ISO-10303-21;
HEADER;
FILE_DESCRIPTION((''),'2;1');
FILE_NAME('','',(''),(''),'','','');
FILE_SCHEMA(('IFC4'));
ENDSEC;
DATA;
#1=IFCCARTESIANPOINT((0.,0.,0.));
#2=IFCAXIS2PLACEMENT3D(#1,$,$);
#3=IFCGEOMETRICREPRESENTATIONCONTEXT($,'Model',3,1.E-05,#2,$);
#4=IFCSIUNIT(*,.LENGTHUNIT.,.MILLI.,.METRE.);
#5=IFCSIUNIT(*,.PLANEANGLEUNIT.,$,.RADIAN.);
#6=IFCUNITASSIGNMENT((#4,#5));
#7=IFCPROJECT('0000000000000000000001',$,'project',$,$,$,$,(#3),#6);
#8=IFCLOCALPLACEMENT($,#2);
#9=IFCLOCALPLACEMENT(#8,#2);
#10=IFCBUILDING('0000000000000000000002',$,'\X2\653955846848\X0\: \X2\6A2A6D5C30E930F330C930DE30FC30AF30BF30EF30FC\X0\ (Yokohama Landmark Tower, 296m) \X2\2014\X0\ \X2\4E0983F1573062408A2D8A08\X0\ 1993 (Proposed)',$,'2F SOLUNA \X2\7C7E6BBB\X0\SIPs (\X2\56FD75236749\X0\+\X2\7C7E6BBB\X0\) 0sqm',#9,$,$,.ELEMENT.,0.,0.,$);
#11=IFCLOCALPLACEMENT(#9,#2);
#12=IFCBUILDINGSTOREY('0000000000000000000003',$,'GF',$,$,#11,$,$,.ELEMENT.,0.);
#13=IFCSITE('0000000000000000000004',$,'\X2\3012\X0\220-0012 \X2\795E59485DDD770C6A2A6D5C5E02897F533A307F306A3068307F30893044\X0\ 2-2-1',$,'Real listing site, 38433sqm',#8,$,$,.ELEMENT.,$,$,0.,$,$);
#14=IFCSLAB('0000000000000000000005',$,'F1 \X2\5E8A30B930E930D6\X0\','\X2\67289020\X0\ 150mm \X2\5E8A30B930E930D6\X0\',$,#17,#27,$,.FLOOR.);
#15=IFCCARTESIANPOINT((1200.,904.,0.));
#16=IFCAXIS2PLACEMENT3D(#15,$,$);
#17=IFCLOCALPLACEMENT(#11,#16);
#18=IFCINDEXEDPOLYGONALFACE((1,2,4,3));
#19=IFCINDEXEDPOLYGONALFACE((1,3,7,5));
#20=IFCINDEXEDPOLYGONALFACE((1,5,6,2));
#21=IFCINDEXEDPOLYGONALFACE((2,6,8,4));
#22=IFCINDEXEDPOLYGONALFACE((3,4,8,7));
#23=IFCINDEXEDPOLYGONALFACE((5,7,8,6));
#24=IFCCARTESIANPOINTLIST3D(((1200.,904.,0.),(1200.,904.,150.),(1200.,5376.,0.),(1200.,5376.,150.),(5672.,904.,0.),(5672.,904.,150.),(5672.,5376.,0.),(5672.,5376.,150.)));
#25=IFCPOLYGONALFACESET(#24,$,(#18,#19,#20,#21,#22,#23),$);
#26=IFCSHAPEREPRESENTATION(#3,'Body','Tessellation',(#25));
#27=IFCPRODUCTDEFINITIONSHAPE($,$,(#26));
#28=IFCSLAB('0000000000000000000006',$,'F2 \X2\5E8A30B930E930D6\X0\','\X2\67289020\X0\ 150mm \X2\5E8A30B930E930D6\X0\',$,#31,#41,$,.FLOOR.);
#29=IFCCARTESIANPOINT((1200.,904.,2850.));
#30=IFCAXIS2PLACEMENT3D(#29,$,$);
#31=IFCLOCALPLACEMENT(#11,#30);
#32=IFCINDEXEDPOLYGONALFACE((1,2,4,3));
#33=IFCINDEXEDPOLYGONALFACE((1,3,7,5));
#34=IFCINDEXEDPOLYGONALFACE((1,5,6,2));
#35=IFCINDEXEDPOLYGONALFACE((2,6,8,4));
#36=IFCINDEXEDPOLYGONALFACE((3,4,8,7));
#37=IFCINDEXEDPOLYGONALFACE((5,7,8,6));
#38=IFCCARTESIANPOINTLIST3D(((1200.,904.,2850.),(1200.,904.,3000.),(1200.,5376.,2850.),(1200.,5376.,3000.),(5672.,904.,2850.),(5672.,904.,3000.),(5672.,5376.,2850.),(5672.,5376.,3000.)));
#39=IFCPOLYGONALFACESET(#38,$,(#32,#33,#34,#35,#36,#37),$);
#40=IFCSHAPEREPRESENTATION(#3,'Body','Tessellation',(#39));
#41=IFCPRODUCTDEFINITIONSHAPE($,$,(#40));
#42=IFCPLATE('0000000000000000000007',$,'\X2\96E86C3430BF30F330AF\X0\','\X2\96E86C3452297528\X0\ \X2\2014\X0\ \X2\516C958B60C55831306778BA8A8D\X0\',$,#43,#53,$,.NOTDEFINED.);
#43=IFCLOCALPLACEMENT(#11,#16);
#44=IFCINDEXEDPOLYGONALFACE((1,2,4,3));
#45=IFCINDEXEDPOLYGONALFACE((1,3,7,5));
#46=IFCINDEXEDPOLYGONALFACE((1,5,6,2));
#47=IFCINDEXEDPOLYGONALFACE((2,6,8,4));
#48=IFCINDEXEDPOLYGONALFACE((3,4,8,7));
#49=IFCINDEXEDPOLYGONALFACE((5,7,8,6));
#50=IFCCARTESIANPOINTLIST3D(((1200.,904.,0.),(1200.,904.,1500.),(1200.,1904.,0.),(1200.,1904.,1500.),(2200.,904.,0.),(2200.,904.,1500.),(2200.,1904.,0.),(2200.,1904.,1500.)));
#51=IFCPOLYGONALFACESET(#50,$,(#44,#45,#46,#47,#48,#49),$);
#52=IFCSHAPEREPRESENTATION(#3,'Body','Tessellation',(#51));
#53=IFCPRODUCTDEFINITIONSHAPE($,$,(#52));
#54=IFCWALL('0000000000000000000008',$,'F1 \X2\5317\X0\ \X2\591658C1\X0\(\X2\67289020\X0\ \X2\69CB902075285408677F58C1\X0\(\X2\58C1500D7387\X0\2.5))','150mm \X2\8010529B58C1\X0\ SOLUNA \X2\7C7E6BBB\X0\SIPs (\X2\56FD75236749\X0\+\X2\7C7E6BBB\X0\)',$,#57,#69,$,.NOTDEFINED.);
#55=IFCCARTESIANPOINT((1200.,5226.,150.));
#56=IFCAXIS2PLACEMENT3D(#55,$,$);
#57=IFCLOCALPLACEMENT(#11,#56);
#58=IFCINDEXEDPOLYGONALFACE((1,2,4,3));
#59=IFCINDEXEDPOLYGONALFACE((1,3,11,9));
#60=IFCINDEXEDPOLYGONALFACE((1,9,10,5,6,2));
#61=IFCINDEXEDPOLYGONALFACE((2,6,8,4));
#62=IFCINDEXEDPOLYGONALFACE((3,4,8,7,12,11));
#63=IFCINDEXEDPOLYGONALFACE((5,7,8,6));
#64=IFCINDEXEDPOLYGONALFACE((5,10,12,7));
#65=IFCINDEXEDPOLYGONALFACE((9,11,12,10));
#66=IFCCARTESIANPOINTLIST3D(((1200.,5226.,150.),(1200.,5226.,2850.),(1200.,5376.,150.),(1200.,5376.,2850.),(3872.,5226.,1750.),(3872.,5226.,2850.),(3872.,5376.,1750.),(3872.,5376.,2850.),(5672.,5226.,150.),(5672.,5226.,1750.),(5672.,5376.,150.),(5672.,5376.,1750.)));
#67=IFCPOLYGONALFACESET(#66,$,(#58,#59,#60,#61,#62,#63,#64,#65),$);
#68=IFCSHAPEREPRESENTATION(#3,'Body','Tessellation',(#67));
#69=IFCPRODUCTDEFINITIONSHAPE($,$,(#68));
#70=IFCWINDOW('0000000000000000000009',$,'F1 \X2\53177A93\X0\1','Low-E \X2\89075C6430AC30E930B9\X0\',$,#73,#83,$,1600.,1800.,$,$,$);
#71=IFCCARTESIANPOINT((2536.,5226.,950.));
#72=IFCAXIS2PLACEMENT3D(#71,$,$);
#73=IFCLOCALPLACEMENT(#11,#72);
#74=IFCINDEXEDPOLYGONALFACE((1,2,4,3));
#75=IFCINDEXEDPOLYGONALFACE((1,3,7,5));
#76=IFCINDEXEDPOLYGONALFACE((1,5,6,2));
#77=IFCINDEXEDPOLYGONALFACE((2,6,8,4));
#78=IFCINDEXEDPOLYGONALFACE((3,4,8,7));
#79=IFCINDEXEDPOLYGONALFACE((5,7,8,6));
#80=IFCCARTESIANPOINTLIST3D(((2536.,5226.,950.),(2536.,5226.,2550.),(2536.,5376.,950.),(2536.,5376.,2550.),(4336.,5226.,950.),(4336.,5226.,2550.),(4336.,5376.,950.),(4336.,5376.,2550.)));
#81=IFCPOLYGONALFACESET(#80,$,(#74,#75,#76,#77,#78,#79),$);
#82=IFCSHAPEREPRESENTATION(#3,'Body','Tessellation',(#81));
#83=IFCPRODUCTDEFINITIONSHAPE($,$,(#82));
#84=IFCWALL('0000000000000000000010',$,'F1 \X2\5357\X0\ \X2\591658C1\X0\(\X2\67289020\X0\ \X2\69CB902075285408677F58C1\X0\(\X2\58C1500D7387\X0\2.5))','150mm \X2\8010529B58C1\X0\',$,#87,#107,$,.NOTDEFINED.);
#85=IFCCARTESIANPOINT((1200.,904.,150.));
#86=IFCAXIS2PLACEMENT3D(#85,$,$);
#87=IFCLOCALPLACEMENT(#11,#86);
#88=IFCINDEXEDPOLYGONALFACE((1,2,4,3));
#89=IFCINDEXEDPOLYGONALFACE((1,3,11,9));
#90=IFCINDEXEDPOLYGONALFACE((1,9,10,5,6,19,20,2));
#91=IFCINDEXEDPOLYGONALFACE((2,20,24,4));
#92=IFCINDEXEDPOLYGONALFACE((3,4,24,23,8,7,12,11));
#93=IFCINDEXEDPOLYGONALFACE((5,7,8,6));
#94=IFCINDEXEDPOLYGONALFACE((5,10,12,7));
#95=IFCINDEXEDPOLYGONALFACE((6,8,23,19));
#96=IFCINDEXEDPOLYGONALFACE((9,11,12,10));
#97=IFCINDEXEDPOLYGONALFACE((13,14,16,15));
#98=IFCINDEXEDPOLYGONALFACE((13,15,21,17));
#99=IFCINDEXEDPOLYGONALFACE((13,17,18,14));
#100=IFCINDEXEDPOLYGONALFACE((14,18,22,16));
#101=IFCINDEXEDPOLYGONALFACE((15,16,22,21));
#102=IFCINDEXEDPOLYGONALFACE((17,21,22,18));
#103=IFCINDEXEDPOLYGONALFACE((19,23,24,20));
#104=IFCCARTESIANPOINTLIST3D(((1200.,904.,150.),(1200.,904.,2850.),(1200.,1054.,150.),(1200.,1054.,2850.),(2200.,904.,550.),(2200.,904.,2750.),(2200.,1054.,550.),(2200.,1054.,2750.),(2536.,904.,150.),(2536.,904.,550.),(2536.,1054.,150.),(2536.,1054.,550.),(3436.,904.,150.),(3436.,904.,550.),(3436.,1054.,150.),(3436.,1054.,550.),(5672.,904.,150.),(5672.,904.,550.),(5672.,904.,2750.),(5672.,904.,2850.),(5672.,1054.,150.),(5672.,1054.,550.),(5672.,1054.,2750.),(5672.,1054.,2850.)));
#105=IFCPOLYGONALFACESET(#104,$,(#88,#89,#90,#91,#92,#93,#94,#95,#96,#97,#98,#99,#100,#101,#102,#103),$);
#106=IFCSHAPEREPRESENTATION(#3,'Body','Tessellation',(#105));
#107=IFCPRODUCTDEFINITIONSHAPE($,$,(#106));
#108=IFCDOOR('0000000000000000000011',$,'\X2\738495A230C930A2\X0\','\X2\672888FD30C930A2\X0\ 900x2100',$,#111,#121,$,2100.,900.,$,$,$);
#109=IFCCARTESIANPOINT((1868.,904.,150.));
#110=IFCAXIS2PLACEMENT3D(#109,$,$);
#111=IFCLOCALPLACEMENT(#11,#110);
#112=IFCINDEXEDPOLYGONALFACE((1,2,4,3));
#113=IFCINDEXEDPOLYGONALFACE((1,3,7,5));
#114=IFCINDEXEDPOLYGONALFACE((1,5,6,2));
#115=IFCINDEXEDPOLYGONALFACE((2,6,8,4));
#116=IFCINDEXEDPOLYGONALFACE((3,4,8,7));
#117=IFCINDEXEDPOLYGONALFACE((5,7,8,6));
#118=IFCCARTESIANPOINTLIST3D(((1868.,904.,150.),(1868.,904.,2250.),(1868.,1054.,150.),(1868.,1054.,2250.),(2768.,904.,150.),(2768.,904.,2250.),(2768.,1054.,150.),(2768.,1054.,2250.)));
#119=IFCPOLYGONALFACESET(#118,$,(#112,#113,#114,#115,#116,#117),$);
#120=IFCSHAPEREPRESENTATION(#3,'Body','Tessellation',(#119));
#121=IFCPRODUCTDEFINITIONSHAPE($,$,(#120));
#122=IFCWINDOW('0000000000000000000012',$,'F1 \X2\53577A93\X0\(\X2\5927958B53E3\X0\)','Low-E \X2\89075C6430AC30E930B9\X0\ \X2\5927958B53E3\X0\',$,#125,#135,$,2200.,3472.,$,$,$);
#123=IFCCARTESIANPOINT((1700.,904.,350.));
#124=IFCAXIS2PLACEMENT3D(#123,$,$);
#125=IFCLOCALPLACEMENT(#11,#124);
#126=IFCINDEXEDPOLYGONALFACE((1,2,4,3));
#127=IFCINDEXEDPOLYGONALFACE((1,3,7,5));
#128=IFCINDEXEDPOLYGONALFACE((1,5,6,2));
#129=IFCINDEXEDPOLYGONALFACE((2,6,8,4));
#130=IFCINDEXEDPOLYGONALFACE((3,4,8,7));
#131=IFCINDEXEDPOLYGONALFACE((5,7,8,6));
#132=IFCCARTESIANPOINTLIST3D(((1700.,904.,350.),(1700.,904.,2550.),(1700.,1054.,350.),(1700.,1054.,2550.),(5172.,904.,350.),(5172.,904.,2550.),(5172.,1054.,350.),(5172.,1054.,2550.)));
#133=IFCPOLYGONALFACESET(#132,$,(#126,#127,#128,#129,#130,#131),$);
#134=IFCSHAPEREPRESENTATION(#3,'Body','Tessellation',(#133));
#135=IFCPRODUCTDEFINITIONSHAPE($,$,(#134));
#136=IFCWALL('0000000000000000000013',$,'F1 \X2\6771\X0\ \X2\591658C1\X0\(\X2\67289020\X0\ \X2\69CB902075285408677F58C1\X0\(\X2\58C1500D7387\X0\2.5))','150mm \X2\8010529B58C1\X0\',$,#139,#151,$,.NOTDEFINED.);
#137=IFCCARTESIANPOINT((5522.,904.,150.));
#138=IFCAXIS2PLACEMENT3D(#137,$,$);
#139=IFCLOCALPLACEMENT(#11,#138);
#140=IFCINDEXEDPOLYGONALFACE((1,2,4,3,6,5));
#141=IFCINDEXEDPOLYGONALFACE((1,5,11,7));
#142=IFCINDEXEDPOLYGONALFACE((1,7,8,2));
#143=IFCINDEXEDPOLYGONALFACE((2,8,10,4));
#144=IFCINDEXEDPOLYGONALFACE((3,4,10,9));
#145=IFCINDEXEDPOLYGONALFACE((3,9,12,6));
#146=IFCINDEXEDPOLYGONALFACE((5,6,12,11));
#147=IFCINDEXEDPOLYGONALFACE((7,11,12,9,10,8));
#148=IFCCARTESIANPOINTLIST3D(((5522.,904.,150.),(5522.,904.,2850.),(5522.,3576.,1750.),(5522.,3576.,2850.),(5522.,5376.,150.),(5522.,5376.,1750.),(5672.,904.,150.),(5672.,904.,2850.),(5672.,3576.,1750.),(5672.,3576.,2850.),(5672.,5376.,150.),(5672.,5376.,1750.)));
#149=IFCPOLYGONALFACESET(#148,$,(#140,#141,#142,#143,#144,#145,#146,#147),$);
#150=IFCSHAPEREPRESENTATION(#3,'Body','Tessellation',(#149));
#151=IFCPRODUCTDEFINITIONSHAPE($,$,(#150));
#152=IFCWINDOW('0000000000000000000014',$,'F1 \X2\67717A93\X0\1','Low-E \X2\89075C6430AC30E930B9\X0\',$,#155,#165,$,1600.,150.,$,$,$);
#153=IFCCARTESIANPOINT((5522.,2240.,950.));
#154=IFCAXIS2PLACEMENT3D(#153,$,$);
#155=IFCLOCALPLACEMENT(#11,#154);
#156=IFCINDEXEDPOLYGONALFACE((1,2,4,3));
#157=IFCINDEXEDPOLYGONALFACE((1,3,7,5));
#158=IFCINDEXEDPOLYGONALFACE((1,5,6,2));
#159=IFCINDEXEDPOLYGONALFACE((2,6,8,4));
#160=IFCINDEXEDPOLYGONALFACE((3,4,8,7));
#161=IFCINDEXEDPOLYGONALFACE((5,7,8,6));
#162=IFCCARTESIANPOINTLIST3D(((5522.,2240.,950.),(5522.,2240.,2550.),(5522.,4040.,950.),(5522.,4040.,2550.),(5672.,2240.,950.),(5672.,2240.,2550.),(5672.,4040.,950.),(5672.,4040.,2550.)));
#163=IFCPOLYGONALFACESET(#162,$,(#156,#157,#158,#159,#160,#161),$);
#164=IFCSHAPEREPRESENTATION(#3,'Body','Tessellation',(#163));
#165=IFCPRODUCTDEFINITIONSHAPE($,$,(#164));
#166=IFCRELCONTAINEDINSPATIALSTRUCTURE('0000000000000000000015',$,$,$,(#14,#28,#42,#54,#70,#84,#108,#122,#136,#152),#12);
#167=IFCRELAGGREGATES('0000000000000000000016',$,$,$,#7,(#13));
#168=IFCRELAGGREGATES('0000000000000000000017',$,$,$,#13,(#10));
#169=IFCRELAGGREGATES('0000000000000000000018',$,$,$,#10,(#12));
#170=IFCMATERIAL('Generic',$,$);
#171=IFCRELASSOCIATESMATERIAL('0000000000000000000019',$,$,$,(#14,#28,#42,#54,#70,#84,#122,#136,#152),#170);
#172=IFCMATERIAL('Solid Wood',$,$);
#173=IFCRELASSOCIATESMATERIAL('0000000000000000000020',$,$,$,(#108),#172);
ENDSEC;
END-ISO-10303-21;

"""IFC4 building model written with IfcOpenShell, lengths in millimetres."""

from ifc_helpers import new_model, si_unit, frame, frame_2d, origin, place, context, project, spatial, rectangle, extrude, material, element, fill, save


model = new_model("IFC4")

# Units and contexts
model_context = context("Model", 3, precision=1e-05, world=origin())
ifc_project = project(units=[si_unit("LENGTHUNIT", "METRE", prefix="MILLI"), si_unit("PLANEANGLEUNIT", "RADIAN")], contexts=[model_context])

# Site, building, storey
site_placement = place(None, origin())
site = spatial("IfcSite", under=ifc_project, at=site_placement, Name="〒220-0012 神奈川県横浜市西区みなとみらい 2-2-1", ObjectType="Real listing site, 38433sqm", CompositionType="ELEMENT", RefElevation=0.0)
building_placement = place(site_placement, origin())
building = spatial("IfcBuilding", under=site, at=building_placement, Name="改善案: 横浜ランドマークタワー (Yokohama Landmark Tower, 296m) — 三菱地所設計 1993 (Proposed)", ObjectType="2F SOLUNA 籾殻SIPs (国産杉+籾殻) 0sqm", CompositionType="ELEMENT", ElevationOfRefHeight=0.0, ElevationOfTerrain=0.0)
storey_placement = place(building_placement, origin())
storey = spatial("IfcBuildingStorey", under=building, at=storey_placement, Name="GF", CompositionType="ELEMENT", Elevation=0.0)

# Slabs
ifc_material_1 = material(Name="Generic")
slab_1_placement = place(storey_placement, frame((1200.0, 904.0, 0.0)))
element("IfcSlab", 1, at=slab_1_placement, inside=storey, material=ifc_material_1, Name="F1 床スラブ", Description="木造 150mm 床スラブ", PredefinedType="FLOOR", context=model_context, shape_type="SweptSolid", body=[
    extrude(rectangle(XDim=4472.0, YDim=4472.0, at=frame_2d((2236.0, 2236.0))), frame((1200.0, 904.0, 0.0)), (0.0, 0.0, 1.0), 150.0),
])
slab_2_placement = place(storey_placement, frame((1200.0, 904.0, 2850.0)))
element("IfcSlab", 2, at=slab_2_placement, inside=storey, material=ifc_material_1, Name="F2 床スラブ", Description="木造 150mm 床スラブ", PredefinedType="FLOOR", context=model_context, shape_type="SweptSolid", body=[
    extrude(rectangle(XDim=4472.0, YDim=4472.0, at=frame_2d((2236.0, 2236.0))), frame((1200.0, 904.0, 2850.0)), (0.0, 0.0, 1.0), 150.0),
])

# Plate
plate_placement = place(storey_placement, frame((1200.0, 904.0, 0.0)))
element("IfcPlate", 3, at=plate_placement, inside=storey, material=ifc_material_1, Name="雨水タンク", Description="雨水利用 — 公開情報で確認", PredefinedType="NOTDEFINED", context=model_context, shape_type="SweptSolid", body=[
    extrude(rectangle(XDim=1000.0, YDim=1000.0, at=frame_2d((500.0, 500.0))), frame((1200.0, 904.0, 0.0)), (0.0, 0.0, 1.0), 1500.0),
])

# Wall, opening, window
wall_1_placement = place(storey_placement, frame((1200.0, 5226.0, 150.0)))
wall_1 = element("IfcWall", 4, at=wall_1_placement, inside=storey, material=ifc_material_1, Name="F1 北 外壁(木造 構造用合板壁(壁倍率2.5))", Description="150mm 耐力壁 SOLUNA 籾殻SIPs (国産杉+籾殻)", PredefinedType="NOTDEFINED", context=model_context, shape_type="SweptSolid", body=[
    extrude(rectangle(XDim=4472.0, YDim=150.0, at=frame_2d((2236.0, 75.0))), frame((1200.0, 5226.0, 150.0)), (0.0, 0.0, 1.0), 2700.0),
])
opening_1_placement = place(storey_placement, frame((2536.0, 5226.0, 950.0)))
opening_1 = element("IfcOpeningElement", 5, at=opening_1_placement, cuts=wall_1, PredefinedType="NOTDEFINED", context=model_context, shape_type="SweptSolid", body=[
    extrude(rectangle(XDim=1800.0, YDim=150.0, at=frame_2d((900.0, 75.0))), frame((2536.0, 5226.0, 950.0)), (0.0, 0.0, 1.0), 1600.0),
])
window_1_placement = place(storey_placement, frame((2536.0, 5226.0, 950.0)))
window_1 = element("IfcWindow", 6, at=window_1_placement, inside=storey, material=ifc_material_1, Name="F1 北窓1", Description="Low-E 複層ガラス", OverallHeight=1600.0, OverallWidth=1800.0, context=model_context, shape_type="SweptSolid", body=[
    extrude(rectangle(XDim=1800.0, YDim=150.0, at=frame_2d((900.0, 75.0))), frame((2536.0, 5226.0, 950.0)), (0.0, 0.0, 1.0), 1600.0),
])
fill(opening_1, window_1)

# Wall, openings, door, window
wall_2_placement = place(storey_placement, frame((1200.0, 904.0, 150.0)))
wall_2 = element("IfcWall", 7, at=wall_2_placement, inside=storey, material=ifc_material_1, Name="F1 南 外壁(木造 構造用合板壁(壁倍率2.5))", Description="150mm 耐力壁", PredefinedType="NOTDEFINED", context=model_context, shape_type="SweptSolid", body=[
    extrude(rectangle(XDim=4472.0, YDim=150.0, at=frame_2d((2236.0, 75.0))), frame((1200.0, 904.0, 150.0)), (0.0, 0.0, 1.0), 2700.0),
])
opening_2_placement = place(storey_placement, frame((1868.0, 904.0, 150.0)))
opening_2 = element("IfcOpeningElement", 8, at=opening_2_placement, cuts=wall_2, PredefinedType="NOTDEFINED", context=model_context, shape_type="SweptSolid", body=[
    extrude(rectangle(XDim=900.0, YDim=150.0, at=frame_2d((450.0, 75.0))), frame((1868.0, 904.0, 150.0)), (0.0, 0.0, 1.0), 2100.0),
])
opening_3_placement = place(storey_placement, frame((1700.0, 904.0, 350.0)))
opening_3 = element("IfcOpeningElement", 9, at=opening_3_placement, cuts=wall_2, PredefinedType="NOTDEFINED", context=model_context, shape_type="SweptSolid", body=[
    extrude(rectangle(XDim=3472.0, YDim=150.0, at=frame_2d((1736.0, 75.0))), frame((1700.0, 904.0, 350.0)), (0.0, 0.0, 1.0), 2200.0),
])
ifc_material_2 = material(Name="Solid Wood")
door_placement = place(storey_placement, frame((1868.0, 904.0, 150.0)))
door = element("IfcDoor", 10, at=door_placement, inside=storey, material=ifc_material_2, Name="玄関ドア", Description="木製ドア 900x2100", OverallHeight=2100.0, OverallWidth=900.0, context=model_context, shape_type="SweptSolid", body=[
    extrude(rectangle(XDim=900.0, YDim=150.0, at=frame_2d((450.0, 75.0))), frame((1868.0, 904.0, 150.0)), (0.0, 0.0, 1.0), 2100.0),
])
fill(opening_2, door)
window_2_placement = place(storey_placement, frame((1700.0, 904.0, 350.0)))
window_2 = element("IfcWindow", 11, at=window_2_placement, inside=storey, material=ifc_material_1, Name="F1 南窓(大開口)", Description="Low-E 複層ガラス 大開口", OverallHeight=2200.0, OverallWidth=3472.0, context=model_context, shape_type="SweptSolid", body=[
    extrude(rectangle(XDim=3472.0, YDim=150.0, at=frame_2d((1736.0, 75.0))), frame((1700.0, 904.0, 350.0)), (0.0, 0.0, 1.0), 2200.0),
])
fill(opening_3, window_2)

# Wall, opening, window
wall_3_placement = place(storey_placement, frame((5522.0, 904.0, 150.0)))
wall_3 = element("IfcWall", 12, at=wall_3_placement, inside=storey, material=ifc_material_1, Name="F1 東 外壁(木造 構造用合板壁(壁倍率2.5))", Description="150mm 耐力壁", PredefinedType="NOTDEFINED", context=model_context, shape_type="SweptSolid", body=[
    extrude(rectangle(XDim=150.0, YDim=4472.0, at=frame_2d((75.0, 2236.0))), frame((5522.0, 904.0, 150.0)), (0.0, 0.0, 1.0), 2700.0),
])
opening_4_placement = place(storey_placement, frame((5522.0, 2240.0, 950.0)))
opening_4 = element("IfcOpeningElement", 13, at=opening_4_placement, cuts=wall_3, PredefinedType="NOTDEFINED", context=model_context, shape_type="SweptSolid", body=[
    extrude(rectangle(XDim=150.0, YDim=1800.0, at=frame_2d((75.0, 900.0))), frame((5522.0, 2240.0, 950.0)), (0.0, 0.0, 1.0), 1600.0),
])
window_3_placement = place(storey_placement, frame((5522.0, 2240.0, 950.0)))
window_3 = element("IfcWindow", 14, at=window_3_placement, inside=storey, material=ifc_material_1, Name="F1 東窓1", Description="Low-E 複層ガラス", OverallHeight=1600.0, OverallWidth=150.0, context=model_context, shape_type="SweptSolid", body=[
    extrude(rectangle(XDim=150.0, YDim=1800.0, at=frame_2d((75.0, 900.0))), frame((5522.0, 2240.0, 950.0)), (0.0, 0.0, 1.0), 1600.0),
])
fill(opening_4, window_3)

save(model, "model.ifc")
